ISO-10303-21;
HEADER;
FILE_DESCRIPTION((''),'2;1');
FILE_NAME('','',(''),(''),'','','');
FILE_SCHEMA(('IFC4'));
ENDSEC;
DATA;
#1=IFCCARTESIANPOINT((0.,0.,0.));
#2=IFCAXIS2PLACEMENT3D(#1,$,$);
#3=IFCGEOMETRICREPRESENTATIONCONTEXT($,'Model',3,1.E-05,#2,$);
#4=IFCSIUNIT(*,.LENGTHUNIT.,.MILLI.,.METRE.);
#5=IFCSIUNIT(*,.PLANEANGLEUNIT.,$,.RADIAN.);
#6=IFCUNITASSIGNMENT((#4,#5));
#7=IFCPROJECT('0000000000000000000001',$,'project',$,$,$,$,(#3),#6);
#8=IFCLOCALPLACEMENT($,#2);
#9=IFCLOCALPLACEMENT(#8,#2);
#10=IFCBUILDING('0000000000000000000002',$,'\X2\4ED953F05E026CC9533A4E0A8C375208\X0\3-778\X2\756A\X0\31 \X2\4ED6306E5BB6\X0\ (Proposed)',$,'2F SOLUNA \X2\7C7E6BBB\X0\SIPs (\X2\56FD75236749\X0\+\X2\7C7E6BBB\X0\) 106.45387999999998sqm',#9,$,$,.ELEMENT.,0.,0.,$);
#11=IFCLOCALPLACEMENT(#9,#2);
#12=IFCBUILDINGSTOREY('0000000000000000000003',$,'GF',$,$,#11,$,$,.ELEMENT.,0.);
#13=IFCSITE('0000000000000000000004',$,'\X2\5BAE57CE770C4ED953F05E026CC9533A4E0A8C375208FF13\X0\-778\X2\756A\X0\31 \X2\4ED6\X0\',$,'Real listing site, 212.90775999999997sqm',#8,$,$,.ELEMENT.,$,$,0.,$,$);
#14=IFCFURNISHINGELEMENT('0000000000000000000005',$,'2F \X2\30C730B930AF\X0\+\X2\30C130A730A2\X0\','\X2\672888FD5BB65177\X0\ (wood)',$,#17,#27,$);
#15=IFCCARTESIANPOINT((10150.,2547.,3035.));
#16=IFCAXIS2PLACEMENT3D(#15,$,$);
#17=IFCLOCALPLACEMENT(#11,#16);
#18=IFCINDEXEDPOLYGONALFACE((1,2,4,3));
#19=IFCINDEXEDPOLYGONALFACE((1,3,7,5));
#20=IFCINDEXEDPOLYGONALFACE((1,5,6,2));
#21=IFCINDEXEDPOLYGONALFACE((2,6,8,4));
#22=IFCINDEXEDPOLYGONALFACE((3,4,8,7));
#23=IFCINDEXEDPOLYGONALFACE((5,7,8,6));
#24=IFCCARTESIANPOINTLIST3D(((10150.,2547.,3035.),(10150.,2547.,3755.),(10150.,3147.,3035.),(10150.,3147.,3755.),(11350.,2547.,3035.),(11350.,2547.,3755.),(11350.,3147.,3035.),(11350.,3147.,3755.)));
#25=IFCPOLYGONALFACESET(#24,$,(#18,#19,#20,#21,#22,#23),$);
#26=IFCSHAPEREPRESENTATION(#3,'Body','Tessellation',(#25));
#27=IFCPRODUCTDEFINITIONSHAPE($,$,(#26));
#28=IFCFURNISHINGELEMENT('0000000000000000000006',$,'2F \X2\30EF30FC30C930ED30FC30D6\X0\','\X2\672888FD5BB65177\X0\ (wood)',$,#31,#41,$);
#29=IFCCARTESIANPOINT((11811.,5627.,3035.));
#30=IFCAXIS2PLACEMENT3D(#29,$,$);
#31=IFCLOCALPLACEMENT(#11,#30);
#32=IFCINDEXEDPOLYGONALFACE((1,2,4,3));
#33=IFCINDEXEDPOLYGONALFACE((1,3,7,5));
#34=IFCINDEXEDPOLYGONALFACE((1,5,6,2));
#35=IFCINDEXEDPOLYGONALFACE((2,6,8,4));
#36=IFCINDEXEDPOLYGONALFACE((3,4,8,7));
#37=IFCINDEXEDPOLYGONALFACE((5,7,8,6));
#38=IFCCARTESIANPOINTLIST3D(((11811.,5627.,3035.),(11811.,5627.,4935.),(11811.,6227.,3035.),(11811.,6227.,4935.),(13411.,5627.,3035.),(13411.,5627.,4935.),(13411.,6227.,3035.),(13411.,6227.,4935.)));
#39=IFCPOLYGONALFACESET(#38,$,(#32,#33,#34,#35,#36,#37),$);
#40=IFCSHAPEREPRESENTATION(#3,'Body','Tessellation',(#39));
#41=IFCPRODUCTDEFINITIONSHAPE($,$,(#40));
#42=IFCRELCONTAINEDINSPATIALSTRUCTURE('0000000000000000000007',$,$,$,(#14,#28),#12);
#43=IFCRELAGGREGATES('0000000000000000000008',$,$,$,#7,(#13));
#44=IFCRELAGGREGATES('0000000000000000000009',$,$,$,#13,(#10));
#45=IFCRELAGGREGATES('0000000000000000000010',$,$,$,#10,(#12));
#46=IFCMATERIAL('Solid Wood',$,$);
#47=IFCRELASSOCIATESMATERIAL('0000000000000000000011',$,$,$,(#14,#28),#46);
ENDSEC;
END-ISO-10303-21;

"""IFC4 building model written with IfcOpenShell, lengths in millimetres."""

from ifc_helpers import new_model, si_unit, frame, frame_2d, origin, place, context, project, spatial, rectangle, extrude, material, element, save


model = new_model("IFC4")

# Units and contexts
model_context = context("Model", 3, precision=1e-05, world=origin())
ifc_project = project(units=[si_unit("LENGTHUNIT", "METRE", prefix="MILLI"), si_unit("PLANEANGLEUNIT", "RADIAN")], contexts=[model_context])

# Site, building, storey
site_placement = place(None, origin())
site = spatial("IfcSite", under=ifc_project, at=site_placement, Name="宮城県仙台市泉区上谷刈３-778番31 他", ObjectType="Real listing site, 212.90775999999997sqm", CompositionType="ELEMENT", RefElevation=0.0)
building_placement = place(site_placement, origin())
building = spatial("IfcBuilding", under=site, at=building_placement, Name="仙台市泉区上谷刈3-778番31 他の家 (Proposed)", ObjectType="2F SOLUNA 籾殻SIPs (国産杉+籾殻) 106.45387999999998sqm", CompositionType="ELEMENT", ElevationOfRefHeight=0.0, ElevationOfTerrain=0.0)
storey_placement = place(building_placement, origin())
storey = spatial("IfcBuildingStorey", under=building, at=storey_placement, Name="GF", CompositionType="ELEMENT", Elevation=0.0)

# Shared definitions
ifc_material_1 = material(Name="Solid Wood")

# Furnishing elements
furnishing_1_placement = place(storey_placement, frame((10150.0, 2547.0, 3035.0)))
element("IfcFurnishingElement", 1, at=furnishing_1_placement, inside=storey, material=ifc_material_1, Name="2F デスク+チェア", Description="木製家具 (wood)", context=model_context, shape_type="SweptSolid", body=[
    extrude(rectangle(XDim=1200.0, YDim=600.0, at=frame_2d((600.0, 300.0))), frame((10150.0, 2547.0, 3035.0)), (0.0, 0.0, 1.0), 720.0),
])
furnishing_2_placement = place(storey_placement, frame((11811.0, 5627.0, 3035.0)))
element("IfcFurnishingElement", 2, at=furnishing_2_placement, inside=storey, material=ifc_material_1, Name="2F ワードローブ", Description="木製家具 (wood)", context=model_context, shape_type="SweptSolid", body=[
    extrude(rectangle(XDim=1600.0, YDim=600.0, at=frame_2d((800.0, 300.0))), frame((11811.0, 5627.0, 3035.0)), (0.0, 0.0, 1.0), 1900.0),
])

save(model, "model.ifc")
